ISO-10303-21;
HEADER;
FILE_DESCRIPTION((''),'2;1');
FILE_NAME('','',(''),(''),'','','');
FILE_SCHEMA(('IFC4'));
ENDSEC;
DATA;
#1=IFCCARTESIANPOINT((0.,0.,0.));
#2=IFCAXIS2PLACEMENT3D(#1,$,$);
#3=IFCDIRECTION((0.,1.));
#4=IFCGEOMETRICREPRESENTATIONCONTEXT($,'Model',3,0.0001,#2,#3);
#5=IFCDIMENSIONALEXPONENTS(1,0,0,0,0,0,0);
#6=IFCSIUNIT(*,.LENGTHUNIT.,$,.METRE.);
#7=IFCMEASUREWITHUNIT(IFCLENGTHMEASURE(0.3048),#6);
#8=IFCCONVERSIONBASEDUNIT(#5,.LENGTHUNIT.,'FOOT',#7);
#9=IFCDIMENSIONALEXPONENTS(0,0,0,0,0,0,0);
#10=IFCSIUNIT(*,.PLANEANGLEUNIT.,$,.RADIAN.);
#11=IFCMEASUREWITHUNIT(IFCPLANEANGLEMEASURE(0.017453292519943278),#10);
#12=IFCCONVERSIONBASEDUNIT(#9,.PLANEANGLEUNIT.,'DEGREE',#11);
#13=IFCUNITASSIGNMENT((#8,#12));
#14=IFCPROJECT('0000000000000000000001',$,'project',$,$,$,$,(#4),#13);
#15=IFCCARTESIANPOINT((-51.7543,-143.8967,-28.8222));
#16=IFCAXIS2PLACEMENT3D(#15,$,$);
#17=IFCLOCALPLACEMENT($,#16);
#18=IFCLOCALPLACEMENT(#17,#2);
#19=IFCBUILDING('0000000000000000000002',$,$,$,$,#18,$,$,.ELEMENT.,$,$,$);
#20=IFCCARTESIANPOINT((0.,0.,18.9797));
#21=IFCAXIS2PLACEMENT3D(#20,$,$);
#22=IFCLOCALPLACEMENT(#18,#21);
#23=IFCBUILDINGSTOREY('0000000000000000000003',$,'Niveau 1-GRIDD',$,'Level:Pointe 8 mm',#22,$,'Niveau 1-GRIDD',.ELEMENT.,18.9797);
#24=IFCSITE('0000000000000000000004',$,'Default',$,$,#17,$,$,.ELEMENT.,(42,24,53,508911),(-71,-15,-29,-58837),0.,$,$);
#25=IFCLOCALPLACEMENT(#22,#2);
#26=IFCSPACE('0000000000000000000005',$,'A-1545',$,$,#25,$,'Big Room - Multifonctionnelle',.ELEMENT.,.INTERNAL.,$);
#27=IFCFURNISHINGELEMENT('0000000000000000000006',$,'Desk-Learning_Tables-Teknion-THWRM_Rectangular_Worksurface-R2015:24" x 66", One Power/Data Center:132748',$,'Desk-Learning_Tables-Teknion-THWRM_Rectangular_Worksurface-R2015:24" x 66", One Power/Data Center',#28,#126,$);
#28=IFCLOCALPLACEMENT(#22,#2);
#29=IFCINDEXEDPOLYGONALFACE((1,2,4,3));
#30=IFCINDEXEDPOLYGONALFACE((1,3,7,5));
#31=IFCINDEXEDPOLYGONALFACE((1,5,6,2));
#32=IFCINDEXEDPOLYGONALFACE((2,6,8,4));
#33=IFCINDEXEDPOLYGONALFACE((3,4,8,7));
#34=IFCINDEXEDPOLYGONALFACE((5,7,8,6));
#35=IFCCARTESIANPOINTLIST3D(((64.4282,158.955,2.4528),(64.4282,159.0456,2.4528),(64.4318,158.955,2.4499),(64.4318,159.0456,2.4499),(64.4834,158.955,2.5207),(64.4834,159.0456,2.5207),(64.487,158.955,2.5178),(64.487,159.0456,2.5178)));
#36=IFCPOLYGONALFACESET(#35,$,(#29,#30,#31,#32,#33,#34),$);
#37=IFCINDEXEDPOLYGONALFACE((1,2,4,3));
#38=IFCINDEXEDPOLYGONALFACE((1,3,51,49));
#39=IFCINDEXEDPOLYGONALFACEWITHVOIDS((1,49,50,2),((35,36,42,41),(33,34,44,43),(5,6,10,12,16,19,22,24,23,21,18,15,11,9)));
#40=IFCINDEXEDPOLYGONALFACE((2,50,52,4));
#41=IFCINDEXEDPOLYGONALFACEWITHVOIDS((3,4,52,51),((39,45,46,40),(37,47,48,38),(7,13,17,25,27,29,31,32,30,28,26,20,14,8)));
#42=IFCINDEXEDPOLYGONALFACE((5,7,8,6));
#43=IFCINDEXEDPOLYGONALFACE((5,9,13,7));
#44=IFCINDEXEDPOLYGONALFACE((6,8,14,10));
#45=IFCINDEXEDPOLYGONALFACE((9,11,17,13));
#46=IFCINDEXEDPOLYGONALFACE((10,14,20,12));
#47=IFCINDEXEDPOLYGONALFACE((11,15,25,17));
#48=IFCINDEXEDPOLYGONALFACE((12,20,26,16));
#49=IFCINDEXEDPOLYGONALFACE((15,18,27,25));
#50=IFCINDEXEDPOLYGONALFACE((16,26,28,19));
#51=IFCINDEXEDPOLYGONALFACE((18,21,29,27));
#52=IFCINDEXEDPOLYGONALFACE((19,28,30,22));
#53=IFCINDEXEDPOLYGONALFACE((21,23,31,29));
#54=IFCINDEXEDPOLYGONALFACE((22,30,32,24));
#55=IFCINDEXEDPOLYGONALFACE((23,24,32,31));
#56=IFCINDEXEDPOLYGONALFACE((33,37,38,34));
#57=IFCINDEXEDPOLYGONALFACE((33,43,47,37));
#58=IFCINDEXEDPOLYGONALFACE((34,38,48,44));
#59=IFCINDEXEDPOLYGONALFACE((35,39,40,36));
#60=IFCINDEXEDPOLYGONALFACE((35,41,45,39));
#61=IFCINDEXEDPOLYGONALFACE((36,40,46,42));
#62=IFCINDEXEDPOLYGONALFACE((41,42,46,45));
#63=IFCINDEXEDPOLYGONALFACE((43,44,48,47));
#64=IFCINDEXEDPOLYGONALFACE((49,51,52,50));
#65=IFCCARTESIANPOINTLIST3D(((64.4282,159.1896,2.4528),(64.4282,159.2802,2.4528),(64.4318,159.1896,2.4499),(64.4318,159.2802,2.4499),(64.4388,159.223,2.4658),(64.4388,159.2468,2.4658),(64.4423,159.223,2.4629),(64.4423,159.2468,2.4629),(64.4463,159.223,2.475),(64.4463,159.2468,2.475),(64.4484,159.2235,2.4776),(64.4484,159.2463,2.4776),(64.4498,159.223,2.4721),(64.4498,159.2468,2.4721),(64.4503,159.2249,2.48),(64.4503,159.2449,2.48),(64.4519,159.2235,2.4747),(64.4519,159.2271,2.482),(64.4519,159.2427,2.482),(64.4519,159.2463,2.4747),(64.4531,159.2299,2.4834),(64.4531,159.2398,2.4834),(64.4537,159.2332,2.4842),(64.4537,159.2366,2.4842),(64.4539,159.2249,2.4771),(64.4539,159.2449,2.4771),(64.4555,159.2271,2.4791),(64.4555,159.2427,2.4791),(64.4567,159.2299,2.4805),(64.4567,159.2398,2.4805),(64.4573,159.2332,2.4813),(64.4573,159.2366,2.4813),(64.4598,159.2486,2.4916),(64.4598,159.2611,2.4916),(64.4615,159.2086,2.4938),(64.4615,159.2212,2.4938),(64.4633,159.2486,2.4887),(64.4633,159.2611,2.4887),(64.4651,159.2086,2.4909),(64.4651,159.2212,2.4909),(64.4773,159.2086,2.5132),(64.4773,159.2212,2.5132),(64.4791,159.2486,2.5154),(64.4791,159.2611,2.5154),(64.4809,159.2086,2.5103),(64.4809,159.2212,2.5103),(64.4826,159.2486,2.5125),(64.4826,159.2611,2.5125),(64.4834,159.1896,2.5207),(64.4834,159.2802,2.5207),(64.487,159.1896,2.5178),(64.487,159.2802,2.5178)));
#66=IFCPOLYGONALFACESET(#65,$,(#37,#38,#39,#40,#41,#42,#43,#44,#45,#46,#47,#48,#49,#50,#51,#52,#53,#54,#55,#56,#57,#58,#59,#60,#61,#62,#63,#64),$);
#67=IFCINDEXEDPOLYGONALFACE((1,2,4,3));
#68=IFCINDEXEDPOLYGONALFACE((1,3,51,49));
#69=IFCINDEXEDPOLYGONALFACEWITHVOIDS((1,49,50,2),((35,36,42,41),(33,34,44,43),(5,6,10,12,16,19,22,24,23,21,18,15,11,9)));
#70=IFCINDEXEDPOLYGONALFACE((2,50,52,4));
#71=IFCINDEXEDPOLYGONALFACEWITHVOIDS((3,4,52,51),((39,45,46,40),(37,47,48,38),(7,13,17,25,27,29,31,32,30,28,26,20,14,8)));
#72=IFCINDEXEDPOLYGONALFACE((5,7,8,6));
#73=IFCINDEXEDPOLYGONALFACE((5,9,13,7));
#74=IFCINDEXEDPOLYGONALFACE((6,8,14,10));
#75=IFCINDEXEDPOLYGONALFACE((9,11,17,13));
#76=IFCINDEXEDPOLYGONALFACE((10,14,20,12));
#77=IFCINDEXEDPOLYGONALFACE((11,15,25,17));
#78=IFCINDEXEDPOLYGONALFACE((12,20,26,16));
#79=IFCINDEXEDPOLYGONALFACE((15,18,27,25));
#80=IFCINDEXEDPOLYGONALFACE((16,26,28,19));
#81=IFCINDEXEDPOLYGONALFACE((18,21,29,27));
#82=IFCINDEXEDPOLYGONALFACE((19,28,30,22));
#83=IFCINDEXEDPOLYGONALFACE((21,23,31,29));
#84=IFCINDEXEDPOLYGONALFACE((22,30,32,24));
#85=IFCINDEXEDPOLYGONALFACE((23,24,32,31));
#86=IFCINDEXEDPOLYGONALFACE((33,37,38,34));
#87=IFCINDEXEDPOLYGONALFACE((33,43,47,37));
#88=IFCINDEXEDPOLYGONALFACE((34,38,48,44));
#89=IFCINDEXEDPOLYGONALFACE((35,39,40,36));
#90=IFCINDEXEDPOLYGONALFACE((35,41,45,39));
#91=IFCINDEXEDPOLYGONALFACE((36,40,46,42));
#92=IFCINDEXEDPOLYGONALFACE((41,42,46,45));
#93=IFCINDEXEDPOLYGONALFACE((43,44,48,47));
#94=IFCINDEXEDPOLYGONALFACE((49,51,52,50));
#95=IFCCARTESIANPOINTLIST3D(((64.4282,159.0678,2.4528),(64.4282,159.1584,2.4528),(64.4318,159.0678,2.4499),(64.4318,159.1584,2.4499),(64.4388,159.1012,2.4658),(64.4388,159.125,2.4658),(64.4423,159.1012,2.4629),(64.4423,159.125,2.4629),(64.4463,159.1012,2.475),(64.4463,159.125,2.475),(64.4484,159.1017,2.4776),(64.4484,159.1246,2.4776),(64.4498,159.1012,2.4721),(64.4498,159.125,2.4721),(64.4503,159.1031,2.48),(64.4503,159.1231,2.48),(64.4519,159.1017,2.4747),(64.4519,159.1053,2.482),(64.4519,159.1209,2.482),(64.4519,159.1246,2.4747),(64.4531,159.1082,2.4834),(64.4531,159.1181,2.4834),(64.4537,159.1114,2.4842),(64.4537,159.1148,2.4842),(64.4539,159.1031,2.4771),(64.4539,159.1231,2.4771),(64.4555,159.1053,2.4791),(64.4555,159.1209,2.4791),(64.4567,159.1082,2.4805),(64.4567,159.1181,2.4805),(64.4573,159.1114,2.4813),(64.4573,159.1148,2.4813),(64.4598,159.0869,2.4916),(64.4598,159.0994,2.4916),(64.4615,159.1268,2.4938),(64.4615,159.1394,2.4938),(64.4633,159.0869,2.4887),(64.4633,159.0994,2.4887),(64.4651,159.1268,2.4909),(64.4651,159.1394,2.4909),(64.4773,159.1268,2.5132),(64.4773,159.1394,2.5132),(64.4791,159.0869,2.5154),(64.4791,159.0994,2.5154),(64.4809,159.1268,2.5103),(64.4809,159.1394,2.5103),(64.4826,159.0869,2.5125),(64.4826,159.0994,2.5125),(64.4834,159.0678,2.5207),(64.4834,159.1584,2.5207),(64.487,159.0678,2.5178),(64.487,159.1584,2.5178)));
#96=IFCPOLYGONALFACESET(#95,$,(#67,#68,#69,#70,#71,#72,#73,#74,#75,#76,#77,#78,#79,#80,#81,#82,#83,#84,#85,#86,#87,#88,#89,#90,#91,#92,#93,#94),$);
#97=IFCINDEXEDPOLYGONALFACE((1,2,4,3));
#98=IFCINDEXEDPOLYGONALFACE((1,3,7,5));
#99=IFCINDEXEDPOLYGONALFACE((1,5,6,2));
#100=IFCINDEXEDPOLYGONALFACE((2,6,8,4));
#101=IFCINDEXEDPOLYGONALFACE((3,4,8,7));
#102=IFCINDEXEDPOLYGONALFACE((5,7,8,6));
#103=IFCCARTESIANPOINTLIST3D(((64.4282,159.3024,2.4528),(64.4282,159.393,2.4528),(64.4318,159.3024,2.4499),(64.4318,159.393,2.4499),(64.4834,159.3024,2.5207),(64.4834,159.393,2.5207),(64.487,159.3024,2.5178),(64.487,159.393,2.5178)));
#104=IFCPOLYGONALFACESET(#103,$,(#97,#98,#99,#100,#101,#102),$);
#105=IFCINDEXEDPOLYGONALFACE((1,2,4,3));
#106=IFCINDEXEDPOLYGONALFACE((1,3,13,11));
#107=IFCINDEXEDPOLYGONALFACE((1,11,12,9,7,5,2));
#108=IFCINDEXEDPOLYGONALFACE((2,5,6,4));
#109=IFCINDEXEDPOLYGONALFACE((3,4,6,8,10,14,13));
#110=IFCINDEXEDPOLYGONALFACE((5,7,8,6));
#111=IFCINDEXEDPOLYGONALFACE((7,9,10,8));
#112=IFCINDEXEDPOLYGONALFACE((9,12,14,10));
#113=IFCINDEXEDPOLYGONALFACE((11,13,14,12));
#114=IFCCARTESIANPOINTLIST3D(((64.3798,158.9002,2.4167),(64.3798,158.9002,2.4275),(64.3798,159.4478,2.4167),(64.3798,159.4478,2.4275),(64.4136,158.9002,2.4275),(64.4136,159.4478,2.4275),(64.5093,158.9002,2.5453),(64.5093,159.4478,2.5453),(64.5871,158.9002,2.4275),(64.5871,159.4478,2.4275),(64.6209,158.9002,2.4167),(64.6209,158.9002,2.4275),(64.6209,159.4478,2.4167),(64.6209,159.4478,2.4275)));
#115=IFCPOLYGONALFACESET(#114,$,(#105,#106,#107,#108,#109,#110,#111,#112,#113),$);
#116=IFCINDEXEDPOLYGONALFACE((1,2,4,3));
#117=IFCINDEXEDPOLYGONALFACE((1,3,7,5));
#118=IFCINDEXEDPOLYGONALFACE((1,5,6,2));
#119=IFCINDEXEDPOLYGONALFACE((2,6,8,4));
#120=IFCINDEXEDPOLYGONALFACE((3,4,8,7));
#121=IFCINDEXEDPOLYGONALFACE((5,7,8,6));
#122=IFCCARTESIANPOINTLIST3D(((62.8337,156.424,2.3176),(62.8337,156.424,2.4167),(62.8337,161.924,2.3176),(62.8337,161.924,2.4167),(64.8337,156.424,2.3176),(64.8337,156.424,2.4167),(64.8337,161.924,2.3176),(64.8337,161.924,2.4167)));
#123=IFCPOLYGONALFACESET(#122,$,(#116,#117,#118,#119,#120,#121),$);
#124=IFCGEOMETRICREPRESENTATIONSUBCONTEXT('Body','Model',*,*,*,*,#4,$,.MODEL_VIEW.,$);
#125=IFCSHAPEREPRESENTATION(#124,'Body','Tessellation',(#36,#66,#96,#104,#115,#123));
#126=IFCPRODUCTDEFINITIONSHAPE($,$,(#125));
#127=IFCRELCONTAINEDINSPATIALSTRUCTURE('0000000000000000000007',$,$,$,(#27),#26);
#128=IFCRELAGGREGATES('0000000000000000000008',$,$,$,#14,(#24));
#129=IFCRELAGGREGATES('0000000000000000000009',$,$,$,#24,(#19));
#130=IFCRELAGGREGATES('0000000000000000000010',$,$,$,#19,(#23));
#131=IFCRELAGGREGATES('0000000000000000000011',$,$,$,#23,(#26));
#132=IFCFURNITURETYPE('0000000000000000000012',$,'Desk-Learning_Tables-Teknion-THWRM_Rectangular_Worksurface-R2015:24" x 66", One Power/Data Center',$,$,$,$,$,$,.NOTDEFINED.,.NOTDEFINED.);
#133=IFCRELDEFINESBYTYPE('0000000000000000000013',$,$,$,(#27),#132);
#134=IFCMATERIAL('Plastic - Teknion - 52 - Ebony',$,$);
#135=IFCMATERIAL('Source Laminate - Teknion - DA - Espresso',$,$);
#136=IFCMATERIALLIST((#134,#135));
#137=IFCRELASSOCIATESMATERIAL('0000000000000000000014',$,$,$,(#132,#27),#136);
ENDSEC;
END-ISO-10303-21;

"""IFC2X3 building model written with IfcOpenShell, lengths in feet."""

from ifc_helpers import new_model, entity, si_unit, converted_unit, direction, frame, frame_2d, origin, place, context, subcontext, project, spatial, polyline, circle_curve, parameter, trimmed, segment, composite_curve, rectangle, outline, extrude, source, transform, mapped, material, material_list, type_object, type_shapes, element, save


model = new_model("IFC2X3")

# Units and contexts
model_context = context("Model", 3, precision=0.0001, world=origin(), true_north=direction((0.0, 1.0)))
body_context = subcontext(model_context, "Body", "Model", "MODEL_VIEW")
ifc_project = project(units=[converted_unit("LENGTHUNIT", "FOOT", entity("IfcLengthMeasure", 0.3048), si_unit("LENGTHUNIT", "METRE"), dimensions=[1, 0, 0, 0, 0, 0, 0]), converted_unit("PLANEANGLEUNIT", "DEGREE", entity("IfcPlaneAngleMeasure", 0.017453292519943278), si_unit("PLANEANGLEUNIT", "RADIAN"), dimensions=[0, 0, 0, 0, 0, 0, 0])], contexts=[model_context])

# Site, building, storey
site_placement = place(None, frame((-51.7543, -143.8967, -28.8222)))
site = spatial("IfcSite", under=ifc_project, at=site_placement, Name="Default", CompositionType="ELEMENT", RefLatitude=(42, 24, 53, 508911), RefLongitude=(-71, -15, -29, -58837), RefElevation=0.0)
building_placement = place(site_placement, origin())
building = spatial("IfcBuilding", under=site, at=building_placement, CompositionType="ELEMENT")
storey_placement = place(building_placement, frame((0.0, 0.0, 18.9797)))
storey = spatial("IfcBuildingStorey", under=building, at=storey_placement, Name="Niveau 1-GRIDD", ObjectType="Level:Pointe 8 mm", LongName="Niveau 1-GRIDD", CompositionType="ELEMENT", Elevation=18.9797)

# Shared definitions
space_placement = place(storey_placement, origin())
space = spatial("IfcSpace", under=storey, at=space_placement, Name="A-1545", LongName="Big Room - Multifonctionnelle", CompositionType="ELEMENT", InteriorOrExteriorSpace="INTERNAL")

# Furnishing element
ifc_material_1 = material(Name="Plastic - Teknion - 52 - Ebony")
ifc_material_2 = material(Name="Source Laminate - Teknion - DA - Espresso")
ifc_material_list_1 = material_list([ifc_material_1, ifc_material_2])
furniture_type_1 = type_object("IfcFurnitureType", Name="Desk-Learning_Tables-Teknion-THWRM_Rectangular_Worksurface-R2015:24\" x 66\", One Power/Data Center", AssemblyPlace="NOTDEFINED", material=ifc_material_list_1)
shared_shape_1 = source(origin(), body_context, "Body", "SweptSolid", [
    extrude(rectangle(XDim=0.0875, YDim=0.0046, at=frame_2d((0.0, 0.0), x_axis=(0.0, 1.0))), frame((0.1284, 0.6239, 2.4853), z_axis=(1.0, 0.0, 0.0), x_axis=(0.0, 0.776046, -0.630676)), (0.0, 0.0, 1.0), 0.0906),
    extrude(outline(polyline([(-0.0453, -0.0438), (0.0453, -0.0438), (0.0453, 0.0438), (-0.0453, 0.0438), (-0.0453, -0.0438)]), holes=[polyline([(-0.0262, -0.0063), (-0.0137, -0.0063), (-0.0137, -0.0369), (-0.0262, -0.0369), (-0.0262, -0.0063)]), polyline([(0.0137, -0.0341), (0.0137, -0.0091), (0.0262, -0.0091), (0.0262, -0.0341), (0.0137, -0.0341)]), composite_curve([segment(polyline([(-0.0119, 0.027), (0.0119, 0.027)]), True, "CONTINUOUS"), segment(polyline([(0.0119, 0.027), (0.0119, 0.0151)]), True, "CONTINUOUS"), segment(trimmed(circle_curve(frame_2d((0.0, 0.0151), x_axis=(0.0, -1.0)), 0.0119), [parameter(270.0)], [parameter(90.0)], True, "PARAMETER"), False, "CONTINUOUS"), segment(polyline([(-0.0119, 0.0151), (-0.0119, 0.027)]), True, "CONTINUOUS")], self_intersect=False)]), frame((-0.0609, 0.6221, 2.4867), z_axis=(0.0, 0.776046, -0.630676), x_axis=(1.0, 0.0, 0.0)), (0.0, 0.0, 1.0), 0.0046),
    extrude(outline(polyline([(-0.0438, -0.0453), (0.0438, -0.0453), (0.0438, 0.0453), (-0.0438, 0.0453), (-0.0438, -0.0453)]), holes=[polyline([(-0.0063, -0.0262), (-0.0369, -0.0262), (-0.0369, -0.0137), (-0.0063, -0.0137), (-0.0063, -0.0262)]), polyline([(-0.0341, 0.0137), (-0.0341, 0.0262), (-0.0091, 0.0262), (-0.0091, 0.0137), (-0.0341, 0.0137)]), composite_curve([segment(polyline([(0.027, -0.0119), (0.0151, -0.0119)]), True, "CONTINUOUS"), segment(trimmed(circle_curve(frame_2d((0.0151, 0.0), x_axis=(-1.0, 0.0)), 0.0119), [parameter(270.0)], [parameter(90.0)], True, "PARAMETER"), False, "CONTINUOUS"), segment(polyline([(0.0151, 0.0119), (0.027, 0.0119)]), True, "CONTINUOUS"), segment(polyline([(0.027, 0.0119), (0.027, -0.0119)]), True, "CONTINUOUS")], self_intersect=False)]), frame((0.0609, 0.6221, 2.4867), z_axis=(0.0, 0.776046, -0.630676), x_axis=(0.0, -0.630676, -0.776046)), (0.0, 0.0, 1.0), 0.0046),
    extrude(rectangle(XDim=0.0875, YDim=0.0046, at=frame_2d((0.0, 0.0), x_axis=(0.0, 1.0))), frame((-0.219, 0.6239, 2.4853), z_axis=(1.0, 0.0, 0.0), x_axis=(0.0, 0.776046, -0.630676)), (0.0, 0.0, 1.0), 0.0906),
    extrude(outline(polyline([(-0.0586, -0.0638), (0.0826, -0.0638), (0.0371, 0.0811), (0.0557, 0.1093), (0.0467, 0.1152), (-0.0862, -0.086), (-0.0772, -0.092), (-0.0586, -0.0638)])), frame((-0.2738, 0.6679, 2.4412), z_axis=(1.0, 0.0, 0.0), x_axis=(0.0, -0.551103, 0.834437)), (0.0, 0.0, 1.0), 0.5475),
    extrude(rectangle(XDim=5.5, YDim=2.0, at=frame_2d((0.0, 0.0), x_axis=(1.0, 0.0))), frame((0.0, 0.0, 2.3176), z_axis=(0.0, 0.0, 1.0), x_axis=(-1.0, 0.0, 0.0)), (0.0, 0.0, 1.0), 0.0991),
])
type_shapes(furniture_type_1, [shared_shape_1])
for number, where, z_axis, x_axis, name in (
    (1, (63.8337, 159.174, 0.0), (0.0, 0.0, 1.0), (0.0, -1.0, 0.0), "Desk-Learning_Tables-Teknion-THWRM_Rectangular_Worksurface-R2015:24\" x 66\", One Power/Data Center:132748"),
):
    element("IfcFurnishingElement", number, at=place(space_placement, frame(where, z_axis=z_axis, x_axis=x_axis)), inside=space, type_object=furniture_type_1, material=ifc_material_list_1, Name=name, ObjectType="Desk-Learning_Tables-Teknion-THWRM_Rectangular_Worksurface-R2015:24\" x 66\", One Power/Data Center", context=body_context, shape_type="MappedRepresentation", body=[
        mapped(shared_shape_1, transform((0.0, 0.0, 0.0), scale=1.0)),
    ])

save(model, "model.ifc")
